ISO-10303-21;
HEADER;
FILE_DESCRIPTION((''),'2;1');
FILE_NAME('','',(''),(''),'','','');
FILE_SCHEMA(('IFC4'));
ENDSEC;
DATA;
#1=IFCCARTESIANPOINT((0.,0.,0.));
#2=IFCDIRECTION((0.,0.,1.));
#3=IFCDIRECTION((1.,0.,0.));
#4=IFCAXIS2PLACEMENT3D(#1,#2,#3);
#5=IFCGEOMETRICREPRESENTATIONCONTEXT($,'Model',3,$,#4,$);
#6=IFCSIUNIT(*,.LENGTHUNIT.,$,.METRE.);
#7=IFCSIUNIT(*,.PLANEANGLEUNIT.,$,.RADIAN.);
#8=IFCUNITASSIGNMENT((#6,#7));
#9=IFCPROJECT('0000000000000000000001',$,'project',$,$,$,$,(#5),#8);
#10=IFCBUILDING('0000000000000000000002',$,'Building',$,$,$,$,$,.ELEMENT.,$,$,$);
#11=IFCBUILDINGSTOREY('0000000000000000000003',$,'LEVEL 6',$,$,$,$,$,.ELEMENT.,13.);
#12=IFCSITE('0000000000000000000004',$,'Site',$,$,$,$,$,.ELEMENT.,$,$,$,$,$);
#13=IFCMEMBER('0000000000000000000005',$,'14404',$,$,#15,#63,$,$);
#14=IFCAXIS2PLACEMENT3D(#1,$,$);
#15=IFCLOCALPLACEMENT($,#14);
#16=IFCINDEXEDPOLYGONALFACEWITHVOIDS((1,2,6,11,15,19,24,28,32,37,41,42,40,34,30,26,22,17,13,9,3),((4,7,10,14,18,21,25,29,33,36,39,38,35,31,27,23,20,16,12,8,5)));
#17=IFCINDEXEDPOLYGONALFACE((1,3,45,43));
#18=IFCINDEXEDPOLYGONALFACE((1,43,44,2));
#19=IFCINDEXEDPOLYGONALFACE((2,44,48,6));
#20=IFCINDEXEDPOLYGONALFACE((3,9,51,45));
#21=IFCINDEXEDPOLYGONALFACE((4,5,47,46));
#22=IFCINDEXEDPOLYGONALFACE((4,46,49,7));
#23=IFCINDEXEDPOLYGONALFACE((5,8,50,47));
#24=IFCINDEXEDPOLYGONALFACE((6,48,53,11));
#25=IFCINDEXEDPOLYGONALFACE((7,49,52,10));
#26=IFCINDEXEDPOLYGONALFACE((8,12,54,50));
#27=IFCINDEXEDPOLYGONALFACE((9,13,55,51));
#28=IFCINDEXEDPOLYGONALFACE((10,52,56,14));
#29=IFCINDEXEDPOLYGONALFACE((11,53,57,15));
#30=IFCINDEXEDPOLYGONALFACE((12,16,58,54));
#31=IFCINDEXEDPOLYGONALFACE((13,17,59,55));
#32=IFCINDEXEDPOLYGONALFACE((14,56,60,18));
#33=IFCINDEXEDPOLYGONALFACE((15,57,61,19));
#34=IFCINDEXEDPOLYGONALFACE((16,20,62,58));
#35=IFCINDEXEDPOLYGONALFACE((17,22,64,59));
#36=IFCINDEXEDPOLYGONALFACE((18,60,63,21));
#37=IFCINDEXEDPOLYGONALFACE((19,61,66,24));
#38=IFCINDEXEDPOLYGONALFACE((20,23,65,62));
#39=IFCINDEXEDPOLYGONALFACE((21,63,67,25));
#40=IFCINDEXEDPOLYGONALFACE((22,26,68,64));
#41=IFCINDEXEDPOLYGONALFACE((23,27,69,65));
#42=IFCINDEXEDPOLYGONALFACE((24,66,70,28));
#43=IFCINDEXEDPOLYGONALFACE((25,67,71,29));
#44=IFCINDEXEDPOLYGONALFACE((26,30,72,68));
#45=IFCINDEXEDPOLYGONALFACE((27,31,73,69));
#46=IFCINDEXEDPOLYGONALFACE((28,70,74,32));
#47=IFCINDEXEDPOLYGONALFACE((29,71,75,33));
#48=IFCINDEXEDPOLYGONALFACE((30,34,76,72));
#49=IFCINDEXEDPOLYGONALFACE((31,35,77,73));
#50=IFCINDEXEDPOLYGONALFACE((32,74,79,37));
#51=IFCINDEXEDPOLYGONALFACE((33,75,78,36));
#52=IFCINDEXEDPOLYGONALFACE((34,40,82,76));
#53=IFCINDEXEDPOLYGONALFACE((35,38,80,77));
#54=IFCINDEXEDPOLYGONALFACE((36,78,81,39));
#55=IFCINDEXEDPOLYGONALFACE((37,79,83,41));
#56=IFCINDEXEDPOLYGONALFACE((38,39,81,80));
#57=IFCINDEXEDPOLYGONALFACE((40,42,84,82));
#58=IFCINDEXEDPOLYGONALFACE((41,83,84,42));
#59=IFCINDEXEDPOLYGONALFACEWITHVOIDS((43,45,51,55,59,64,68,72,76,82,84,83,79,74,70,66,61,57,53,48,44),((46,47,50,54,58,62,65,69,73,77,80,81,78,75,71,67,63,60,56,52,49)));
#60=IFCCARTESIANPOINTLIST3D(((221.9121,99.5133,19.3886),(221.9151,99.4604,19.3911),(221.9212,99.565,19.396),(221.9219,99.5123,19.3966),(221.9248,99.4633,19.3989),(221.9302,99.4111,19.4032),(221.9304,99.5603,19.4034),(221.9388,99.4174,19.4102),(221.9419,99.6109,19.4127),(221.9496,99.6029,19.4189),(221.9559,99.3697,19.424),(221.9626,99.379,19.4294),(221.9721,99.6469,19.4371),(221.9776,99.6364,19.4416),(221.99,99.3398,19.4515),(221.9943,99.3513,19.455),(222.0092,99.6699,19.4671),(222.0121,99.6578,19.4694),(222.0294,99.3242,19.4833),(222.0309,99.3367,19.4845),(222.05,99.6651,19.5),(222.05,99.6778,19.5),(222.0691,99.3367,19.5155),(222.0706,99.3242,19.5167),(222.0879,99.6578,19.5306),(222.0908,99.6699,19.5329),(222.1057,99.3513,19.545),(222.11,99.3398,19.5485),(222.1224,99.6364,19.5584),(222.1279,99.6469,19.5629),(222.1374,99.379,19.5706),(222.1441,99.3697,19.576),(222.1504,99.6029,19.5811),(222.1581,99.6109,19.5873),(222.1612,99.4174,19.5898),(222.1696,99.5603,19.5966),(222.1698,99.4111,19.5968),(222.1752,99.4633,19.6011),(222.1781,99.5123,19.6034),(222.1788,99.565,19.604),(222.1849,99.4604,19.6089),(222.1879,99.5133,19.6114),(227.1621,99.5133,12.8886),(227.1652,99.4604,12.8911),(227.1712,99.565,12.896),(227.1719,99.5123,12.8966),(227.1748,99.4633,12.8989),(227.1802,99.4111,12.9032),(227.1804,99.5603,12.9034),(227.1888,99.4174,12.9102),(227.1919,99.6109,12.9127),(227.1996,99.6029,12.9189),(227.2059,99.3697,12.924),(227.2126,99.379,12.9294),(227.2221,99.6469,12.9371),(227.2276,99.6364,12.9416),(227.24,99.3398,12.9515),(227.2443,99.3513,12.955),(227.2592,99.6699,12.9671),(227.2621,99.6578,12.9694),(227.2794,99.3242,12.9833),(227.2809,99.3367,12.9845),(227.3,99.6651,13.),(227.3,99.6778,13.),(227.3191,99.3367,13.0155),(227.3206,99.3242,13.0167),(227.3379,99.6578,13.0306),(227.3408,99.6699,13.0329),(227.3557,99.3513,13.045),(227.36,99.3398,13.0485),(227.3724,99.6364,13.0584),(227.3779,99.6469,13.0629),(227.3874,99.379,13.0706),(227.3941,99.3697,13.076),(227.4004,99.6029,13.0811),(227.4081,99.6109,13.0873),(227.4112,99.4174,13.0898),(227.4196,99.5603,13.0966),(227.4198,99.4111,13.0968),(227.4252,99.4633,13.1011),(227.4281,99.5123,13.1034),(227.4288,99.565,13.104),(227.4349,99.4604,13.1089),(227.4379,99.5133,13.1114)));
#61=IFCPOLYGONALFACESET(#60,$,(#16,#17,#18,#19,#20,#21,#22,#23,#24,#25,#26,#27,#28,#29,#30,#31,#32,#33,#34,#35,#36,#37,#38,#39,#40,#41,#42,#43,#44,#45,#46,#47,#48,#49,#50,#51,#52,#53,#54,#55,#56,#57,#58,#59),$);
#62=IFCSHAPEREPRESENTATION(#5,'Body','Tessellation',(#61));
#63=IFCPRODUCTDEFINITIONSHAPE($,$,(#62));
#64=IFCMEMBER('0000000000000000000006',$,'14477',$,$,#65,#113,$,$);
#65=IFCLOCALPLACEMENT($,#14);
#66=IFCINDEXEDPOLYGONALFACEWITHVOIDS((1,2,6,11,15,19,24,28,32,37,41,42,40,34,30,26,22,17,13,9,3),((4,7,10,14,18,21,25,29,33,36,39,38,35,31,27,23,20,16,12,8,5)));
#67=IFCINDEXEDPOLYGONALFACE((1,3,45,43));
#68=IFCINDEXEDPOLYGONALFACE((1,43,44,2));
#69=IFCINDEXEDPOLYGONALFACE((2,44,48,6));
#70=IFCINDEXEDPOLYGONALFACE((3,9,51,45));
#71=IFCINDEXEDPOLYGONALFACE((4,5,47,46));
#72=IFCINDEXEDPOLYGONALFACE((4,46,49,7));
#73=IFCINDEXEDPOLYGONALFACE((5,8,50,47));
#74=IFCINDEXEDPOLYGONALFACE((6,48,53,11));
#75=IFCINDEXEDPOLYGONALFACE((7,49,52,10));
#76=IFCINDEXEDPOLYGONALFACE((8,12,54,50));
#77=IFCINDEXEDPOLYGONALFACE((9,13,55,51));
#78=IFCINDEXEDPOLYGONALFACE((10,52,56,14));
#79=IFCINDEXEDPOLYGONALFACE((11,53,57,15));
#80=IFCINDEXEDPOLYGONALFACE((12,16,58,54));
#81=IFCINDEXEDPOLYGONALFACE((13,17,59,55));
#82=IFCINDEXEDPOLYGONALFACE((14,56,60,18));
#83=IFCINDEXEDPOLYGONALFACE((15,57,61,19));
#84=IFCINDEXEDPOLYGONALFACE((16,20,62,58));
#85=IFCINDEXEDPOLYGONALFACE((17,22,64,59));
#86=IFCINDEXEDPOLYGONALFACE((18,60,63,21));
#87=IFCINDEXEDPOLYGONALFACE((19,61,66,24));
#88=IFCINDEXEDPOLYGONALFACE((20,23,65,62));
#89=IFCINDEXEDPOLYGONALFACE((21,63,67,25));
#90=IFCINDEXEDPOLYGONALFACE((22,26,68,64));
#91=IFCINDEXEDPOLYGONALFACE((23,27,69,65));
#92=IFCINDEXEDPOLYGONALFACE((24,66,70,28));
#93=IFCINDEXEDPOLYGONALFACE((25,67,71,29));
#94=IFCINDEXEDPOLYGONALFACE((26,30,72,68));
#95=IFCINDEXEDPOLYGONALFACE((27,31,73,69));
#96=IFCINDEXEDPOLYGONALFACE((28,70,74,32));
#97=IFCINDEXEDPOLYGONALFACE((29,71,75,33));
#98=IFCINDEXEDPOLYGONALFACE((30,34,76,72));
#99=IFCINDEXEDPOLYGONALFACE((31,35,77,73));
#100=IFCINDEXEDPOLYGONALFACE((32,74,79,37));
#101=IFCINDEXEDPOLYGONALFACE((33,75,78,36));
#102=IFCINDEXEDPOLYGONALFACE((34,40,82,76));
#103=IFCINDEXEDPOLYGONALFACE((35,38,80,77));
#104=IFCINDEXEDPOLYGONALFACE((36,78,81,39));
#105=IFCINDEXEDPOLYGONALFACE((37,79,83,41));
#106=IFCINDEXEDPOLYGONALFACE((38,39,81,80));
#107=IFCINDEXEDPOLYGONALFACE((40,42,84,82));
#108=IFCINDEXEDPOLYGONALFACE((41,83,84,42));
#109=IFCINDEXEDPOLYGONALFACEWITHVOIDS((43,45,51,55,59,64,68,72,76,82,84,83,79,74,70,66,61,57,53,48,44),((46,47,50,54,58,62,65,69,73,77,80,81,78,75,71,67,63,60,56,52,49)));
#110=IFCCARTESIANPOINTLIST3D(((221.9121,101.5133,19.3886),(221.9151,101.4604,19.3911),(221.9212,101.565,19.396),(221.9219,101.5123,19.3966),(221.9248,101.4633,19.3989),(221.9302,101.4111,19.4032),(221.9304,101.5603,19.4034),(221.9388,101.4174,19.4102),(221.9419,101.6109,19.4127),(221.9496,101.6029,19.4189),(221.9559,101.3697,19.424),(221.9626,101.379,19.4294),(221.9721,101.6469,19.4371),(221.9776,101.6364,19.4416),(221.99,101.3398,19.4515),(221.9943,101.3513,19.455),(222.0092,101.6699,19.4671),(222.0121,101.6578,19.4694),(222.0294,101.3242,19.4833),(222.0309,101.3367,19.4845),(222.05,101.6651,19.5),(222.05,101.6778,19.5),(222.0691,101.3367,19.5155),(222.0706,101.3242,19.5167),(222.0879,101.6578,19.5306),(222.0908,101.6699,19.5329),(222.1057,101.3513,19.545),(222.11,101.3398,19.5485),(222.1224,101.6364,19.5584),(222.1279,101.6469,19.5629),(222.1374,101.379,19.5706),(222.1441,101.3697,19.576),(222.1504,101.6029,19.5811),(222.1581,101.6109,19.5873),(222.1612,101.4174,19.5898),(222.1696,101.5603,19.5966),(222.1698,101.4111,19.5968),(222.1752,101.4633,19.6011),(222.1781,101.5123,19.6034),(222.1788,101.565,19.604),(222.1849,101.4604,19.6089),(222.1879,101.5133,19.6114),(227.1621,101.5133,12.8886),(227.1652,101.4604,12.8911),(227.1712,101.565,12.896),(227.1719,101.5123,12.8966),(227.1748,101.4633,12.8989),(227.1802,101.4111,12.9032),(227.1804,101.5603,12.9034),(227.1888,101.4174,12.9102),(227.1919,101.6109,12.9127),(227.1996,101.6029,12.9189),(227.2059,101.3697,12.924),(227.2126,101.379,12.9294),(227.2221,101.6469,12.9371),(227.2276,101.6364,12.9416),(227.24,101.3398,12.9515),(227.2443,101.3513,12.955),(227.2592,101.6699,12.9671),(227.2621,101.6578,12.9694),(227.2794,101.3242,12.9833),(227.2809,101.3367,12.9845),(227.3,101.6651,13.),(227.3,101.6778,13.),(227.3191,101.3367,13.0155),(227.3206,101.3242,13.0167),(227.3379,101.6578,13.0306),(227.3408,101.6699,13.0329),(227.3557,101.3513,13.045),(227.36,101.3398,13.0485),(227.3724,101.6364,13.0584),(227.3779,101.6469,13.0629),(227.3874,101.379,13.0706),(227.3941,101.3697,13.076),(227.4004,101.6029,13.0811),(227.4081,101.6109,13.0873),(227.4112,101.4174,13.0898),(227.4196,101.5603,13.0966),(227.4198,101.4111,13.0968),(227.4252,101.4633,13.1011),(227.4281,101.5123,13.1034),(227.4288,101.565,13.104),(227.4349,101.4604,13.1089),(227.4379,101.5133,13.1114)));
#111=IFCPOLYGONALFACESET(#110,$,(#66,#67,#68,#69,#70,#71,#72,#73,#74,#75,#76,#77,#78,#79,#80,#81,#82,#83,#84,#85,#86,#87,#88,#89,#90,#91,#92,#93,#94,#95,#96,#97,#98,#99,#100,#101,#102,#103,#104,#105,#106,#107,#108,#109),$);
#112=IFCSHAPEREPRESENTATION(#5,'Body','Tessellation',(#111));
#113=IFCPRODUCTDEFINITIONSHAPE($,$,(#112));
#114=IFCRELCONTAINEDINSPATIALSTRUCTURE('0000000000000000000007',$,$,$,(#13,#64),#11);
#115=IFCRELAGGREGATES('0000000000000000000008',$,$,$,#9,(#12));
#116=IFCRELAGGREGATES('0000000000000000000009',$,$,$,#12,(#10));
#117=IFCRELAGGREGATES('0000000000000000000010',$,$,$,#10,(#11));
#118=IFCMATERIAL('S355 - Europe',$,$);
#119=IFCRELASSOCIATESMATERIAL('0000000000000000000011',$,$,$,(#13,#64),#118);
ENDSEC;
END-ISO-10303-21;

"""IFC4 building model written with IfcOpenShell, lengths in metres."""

from ifc_helpers import new_model, si_unit, frame, origin_with_axes, origin_2d_with_axis, place, context, project, spatial, hollow_circle, extrude, material, material_profile, profile_set, profile_usage, element, save


model = new_model("IFC4")

# Units and contexts
model_context = context("Model", 3, world=origin_with_axes())
ifc_project = project(units=[si_unit("LENGTHUNIT", "METRE"), si_unit("PLANEANGLEUNIT", "RADIAN")], contexts=[model_context])

# Site, building, storey
site = spatial("IfcSite", under=ifc_project, Name="Site", CompositionType="ELEMENT")
building = spatial("IfcBuilding", under=site, Name="Building", CompositionType="ELEMENT")
storey = spatial("IfcBuildingStorey", under=building, Name="LEVEL 6", CompositionType="ELEMENT", Elevation=13.0)

# Shared definitions
ifc_material = material(Name="S355 - Europe")

# Members
ifc_material_profile_1 = material_profile(ifc_material, hollow_circle(Radius=0.1778, WallThickness=0.0127, at=origin_2d_with_axis()))
ifc_profile_set_1 = profile_set([ifc_material_profile_1])
ifc_profile_usage_1 = profile_usage(ifc_profile_set_1, cardinal=10)
member_1_placement = place(None, frame((222.05, 99.5, 19.5), z_axis=(0.628337, 0.0, -0.777941), x_axis=(0.0, 1.0, 0.0)))
element("IfcMember", 1, at=member_1_placement, inside=storey, material=ifc_profile_usage_1, Name="14404", context=model_context, shape_type="SweptSolid", body=[
    extrude(hollow_circle(Radius=0.1778, WallThickness=0.0127, at=origin_2d_with_axis()), origin_with_axes(), (0.0, 0.0, 1.0), 8.3554),
])
ifc_material_profile_2 = material_profile(ifc_material, hollow_circle(Radius=0.1778, WallThickness=0.0127, at=origin_2d_with_axis()))
ifc_profile_set_2 = profile_set([ifc_material_profile_2])
ifc_profile_usage_2 = profile_usage(ifc_profile_set_2, cardinal=10)
member_2_placement = place(None, frame((222.05, 101.5, 19.5), z_axis=(0.628337, 0.0, -0.777941), x_axis=(0.0, 1.0, 0.0)))
element("IfcMember", 2, at=member_2_placement, inside=storey, material=ifc_profile_usage_2, Name="14477", context=model_context, shape_type="SweptSolid", body=[
    extrude(hollow_circle(Radius=0.1778, WallThickness=0.0127, at=origin_2d_with_axis()), origin_with_axes(), (0.0, 0.0, 1.0), 8.3554),
])

save(model, "model.ifc")
